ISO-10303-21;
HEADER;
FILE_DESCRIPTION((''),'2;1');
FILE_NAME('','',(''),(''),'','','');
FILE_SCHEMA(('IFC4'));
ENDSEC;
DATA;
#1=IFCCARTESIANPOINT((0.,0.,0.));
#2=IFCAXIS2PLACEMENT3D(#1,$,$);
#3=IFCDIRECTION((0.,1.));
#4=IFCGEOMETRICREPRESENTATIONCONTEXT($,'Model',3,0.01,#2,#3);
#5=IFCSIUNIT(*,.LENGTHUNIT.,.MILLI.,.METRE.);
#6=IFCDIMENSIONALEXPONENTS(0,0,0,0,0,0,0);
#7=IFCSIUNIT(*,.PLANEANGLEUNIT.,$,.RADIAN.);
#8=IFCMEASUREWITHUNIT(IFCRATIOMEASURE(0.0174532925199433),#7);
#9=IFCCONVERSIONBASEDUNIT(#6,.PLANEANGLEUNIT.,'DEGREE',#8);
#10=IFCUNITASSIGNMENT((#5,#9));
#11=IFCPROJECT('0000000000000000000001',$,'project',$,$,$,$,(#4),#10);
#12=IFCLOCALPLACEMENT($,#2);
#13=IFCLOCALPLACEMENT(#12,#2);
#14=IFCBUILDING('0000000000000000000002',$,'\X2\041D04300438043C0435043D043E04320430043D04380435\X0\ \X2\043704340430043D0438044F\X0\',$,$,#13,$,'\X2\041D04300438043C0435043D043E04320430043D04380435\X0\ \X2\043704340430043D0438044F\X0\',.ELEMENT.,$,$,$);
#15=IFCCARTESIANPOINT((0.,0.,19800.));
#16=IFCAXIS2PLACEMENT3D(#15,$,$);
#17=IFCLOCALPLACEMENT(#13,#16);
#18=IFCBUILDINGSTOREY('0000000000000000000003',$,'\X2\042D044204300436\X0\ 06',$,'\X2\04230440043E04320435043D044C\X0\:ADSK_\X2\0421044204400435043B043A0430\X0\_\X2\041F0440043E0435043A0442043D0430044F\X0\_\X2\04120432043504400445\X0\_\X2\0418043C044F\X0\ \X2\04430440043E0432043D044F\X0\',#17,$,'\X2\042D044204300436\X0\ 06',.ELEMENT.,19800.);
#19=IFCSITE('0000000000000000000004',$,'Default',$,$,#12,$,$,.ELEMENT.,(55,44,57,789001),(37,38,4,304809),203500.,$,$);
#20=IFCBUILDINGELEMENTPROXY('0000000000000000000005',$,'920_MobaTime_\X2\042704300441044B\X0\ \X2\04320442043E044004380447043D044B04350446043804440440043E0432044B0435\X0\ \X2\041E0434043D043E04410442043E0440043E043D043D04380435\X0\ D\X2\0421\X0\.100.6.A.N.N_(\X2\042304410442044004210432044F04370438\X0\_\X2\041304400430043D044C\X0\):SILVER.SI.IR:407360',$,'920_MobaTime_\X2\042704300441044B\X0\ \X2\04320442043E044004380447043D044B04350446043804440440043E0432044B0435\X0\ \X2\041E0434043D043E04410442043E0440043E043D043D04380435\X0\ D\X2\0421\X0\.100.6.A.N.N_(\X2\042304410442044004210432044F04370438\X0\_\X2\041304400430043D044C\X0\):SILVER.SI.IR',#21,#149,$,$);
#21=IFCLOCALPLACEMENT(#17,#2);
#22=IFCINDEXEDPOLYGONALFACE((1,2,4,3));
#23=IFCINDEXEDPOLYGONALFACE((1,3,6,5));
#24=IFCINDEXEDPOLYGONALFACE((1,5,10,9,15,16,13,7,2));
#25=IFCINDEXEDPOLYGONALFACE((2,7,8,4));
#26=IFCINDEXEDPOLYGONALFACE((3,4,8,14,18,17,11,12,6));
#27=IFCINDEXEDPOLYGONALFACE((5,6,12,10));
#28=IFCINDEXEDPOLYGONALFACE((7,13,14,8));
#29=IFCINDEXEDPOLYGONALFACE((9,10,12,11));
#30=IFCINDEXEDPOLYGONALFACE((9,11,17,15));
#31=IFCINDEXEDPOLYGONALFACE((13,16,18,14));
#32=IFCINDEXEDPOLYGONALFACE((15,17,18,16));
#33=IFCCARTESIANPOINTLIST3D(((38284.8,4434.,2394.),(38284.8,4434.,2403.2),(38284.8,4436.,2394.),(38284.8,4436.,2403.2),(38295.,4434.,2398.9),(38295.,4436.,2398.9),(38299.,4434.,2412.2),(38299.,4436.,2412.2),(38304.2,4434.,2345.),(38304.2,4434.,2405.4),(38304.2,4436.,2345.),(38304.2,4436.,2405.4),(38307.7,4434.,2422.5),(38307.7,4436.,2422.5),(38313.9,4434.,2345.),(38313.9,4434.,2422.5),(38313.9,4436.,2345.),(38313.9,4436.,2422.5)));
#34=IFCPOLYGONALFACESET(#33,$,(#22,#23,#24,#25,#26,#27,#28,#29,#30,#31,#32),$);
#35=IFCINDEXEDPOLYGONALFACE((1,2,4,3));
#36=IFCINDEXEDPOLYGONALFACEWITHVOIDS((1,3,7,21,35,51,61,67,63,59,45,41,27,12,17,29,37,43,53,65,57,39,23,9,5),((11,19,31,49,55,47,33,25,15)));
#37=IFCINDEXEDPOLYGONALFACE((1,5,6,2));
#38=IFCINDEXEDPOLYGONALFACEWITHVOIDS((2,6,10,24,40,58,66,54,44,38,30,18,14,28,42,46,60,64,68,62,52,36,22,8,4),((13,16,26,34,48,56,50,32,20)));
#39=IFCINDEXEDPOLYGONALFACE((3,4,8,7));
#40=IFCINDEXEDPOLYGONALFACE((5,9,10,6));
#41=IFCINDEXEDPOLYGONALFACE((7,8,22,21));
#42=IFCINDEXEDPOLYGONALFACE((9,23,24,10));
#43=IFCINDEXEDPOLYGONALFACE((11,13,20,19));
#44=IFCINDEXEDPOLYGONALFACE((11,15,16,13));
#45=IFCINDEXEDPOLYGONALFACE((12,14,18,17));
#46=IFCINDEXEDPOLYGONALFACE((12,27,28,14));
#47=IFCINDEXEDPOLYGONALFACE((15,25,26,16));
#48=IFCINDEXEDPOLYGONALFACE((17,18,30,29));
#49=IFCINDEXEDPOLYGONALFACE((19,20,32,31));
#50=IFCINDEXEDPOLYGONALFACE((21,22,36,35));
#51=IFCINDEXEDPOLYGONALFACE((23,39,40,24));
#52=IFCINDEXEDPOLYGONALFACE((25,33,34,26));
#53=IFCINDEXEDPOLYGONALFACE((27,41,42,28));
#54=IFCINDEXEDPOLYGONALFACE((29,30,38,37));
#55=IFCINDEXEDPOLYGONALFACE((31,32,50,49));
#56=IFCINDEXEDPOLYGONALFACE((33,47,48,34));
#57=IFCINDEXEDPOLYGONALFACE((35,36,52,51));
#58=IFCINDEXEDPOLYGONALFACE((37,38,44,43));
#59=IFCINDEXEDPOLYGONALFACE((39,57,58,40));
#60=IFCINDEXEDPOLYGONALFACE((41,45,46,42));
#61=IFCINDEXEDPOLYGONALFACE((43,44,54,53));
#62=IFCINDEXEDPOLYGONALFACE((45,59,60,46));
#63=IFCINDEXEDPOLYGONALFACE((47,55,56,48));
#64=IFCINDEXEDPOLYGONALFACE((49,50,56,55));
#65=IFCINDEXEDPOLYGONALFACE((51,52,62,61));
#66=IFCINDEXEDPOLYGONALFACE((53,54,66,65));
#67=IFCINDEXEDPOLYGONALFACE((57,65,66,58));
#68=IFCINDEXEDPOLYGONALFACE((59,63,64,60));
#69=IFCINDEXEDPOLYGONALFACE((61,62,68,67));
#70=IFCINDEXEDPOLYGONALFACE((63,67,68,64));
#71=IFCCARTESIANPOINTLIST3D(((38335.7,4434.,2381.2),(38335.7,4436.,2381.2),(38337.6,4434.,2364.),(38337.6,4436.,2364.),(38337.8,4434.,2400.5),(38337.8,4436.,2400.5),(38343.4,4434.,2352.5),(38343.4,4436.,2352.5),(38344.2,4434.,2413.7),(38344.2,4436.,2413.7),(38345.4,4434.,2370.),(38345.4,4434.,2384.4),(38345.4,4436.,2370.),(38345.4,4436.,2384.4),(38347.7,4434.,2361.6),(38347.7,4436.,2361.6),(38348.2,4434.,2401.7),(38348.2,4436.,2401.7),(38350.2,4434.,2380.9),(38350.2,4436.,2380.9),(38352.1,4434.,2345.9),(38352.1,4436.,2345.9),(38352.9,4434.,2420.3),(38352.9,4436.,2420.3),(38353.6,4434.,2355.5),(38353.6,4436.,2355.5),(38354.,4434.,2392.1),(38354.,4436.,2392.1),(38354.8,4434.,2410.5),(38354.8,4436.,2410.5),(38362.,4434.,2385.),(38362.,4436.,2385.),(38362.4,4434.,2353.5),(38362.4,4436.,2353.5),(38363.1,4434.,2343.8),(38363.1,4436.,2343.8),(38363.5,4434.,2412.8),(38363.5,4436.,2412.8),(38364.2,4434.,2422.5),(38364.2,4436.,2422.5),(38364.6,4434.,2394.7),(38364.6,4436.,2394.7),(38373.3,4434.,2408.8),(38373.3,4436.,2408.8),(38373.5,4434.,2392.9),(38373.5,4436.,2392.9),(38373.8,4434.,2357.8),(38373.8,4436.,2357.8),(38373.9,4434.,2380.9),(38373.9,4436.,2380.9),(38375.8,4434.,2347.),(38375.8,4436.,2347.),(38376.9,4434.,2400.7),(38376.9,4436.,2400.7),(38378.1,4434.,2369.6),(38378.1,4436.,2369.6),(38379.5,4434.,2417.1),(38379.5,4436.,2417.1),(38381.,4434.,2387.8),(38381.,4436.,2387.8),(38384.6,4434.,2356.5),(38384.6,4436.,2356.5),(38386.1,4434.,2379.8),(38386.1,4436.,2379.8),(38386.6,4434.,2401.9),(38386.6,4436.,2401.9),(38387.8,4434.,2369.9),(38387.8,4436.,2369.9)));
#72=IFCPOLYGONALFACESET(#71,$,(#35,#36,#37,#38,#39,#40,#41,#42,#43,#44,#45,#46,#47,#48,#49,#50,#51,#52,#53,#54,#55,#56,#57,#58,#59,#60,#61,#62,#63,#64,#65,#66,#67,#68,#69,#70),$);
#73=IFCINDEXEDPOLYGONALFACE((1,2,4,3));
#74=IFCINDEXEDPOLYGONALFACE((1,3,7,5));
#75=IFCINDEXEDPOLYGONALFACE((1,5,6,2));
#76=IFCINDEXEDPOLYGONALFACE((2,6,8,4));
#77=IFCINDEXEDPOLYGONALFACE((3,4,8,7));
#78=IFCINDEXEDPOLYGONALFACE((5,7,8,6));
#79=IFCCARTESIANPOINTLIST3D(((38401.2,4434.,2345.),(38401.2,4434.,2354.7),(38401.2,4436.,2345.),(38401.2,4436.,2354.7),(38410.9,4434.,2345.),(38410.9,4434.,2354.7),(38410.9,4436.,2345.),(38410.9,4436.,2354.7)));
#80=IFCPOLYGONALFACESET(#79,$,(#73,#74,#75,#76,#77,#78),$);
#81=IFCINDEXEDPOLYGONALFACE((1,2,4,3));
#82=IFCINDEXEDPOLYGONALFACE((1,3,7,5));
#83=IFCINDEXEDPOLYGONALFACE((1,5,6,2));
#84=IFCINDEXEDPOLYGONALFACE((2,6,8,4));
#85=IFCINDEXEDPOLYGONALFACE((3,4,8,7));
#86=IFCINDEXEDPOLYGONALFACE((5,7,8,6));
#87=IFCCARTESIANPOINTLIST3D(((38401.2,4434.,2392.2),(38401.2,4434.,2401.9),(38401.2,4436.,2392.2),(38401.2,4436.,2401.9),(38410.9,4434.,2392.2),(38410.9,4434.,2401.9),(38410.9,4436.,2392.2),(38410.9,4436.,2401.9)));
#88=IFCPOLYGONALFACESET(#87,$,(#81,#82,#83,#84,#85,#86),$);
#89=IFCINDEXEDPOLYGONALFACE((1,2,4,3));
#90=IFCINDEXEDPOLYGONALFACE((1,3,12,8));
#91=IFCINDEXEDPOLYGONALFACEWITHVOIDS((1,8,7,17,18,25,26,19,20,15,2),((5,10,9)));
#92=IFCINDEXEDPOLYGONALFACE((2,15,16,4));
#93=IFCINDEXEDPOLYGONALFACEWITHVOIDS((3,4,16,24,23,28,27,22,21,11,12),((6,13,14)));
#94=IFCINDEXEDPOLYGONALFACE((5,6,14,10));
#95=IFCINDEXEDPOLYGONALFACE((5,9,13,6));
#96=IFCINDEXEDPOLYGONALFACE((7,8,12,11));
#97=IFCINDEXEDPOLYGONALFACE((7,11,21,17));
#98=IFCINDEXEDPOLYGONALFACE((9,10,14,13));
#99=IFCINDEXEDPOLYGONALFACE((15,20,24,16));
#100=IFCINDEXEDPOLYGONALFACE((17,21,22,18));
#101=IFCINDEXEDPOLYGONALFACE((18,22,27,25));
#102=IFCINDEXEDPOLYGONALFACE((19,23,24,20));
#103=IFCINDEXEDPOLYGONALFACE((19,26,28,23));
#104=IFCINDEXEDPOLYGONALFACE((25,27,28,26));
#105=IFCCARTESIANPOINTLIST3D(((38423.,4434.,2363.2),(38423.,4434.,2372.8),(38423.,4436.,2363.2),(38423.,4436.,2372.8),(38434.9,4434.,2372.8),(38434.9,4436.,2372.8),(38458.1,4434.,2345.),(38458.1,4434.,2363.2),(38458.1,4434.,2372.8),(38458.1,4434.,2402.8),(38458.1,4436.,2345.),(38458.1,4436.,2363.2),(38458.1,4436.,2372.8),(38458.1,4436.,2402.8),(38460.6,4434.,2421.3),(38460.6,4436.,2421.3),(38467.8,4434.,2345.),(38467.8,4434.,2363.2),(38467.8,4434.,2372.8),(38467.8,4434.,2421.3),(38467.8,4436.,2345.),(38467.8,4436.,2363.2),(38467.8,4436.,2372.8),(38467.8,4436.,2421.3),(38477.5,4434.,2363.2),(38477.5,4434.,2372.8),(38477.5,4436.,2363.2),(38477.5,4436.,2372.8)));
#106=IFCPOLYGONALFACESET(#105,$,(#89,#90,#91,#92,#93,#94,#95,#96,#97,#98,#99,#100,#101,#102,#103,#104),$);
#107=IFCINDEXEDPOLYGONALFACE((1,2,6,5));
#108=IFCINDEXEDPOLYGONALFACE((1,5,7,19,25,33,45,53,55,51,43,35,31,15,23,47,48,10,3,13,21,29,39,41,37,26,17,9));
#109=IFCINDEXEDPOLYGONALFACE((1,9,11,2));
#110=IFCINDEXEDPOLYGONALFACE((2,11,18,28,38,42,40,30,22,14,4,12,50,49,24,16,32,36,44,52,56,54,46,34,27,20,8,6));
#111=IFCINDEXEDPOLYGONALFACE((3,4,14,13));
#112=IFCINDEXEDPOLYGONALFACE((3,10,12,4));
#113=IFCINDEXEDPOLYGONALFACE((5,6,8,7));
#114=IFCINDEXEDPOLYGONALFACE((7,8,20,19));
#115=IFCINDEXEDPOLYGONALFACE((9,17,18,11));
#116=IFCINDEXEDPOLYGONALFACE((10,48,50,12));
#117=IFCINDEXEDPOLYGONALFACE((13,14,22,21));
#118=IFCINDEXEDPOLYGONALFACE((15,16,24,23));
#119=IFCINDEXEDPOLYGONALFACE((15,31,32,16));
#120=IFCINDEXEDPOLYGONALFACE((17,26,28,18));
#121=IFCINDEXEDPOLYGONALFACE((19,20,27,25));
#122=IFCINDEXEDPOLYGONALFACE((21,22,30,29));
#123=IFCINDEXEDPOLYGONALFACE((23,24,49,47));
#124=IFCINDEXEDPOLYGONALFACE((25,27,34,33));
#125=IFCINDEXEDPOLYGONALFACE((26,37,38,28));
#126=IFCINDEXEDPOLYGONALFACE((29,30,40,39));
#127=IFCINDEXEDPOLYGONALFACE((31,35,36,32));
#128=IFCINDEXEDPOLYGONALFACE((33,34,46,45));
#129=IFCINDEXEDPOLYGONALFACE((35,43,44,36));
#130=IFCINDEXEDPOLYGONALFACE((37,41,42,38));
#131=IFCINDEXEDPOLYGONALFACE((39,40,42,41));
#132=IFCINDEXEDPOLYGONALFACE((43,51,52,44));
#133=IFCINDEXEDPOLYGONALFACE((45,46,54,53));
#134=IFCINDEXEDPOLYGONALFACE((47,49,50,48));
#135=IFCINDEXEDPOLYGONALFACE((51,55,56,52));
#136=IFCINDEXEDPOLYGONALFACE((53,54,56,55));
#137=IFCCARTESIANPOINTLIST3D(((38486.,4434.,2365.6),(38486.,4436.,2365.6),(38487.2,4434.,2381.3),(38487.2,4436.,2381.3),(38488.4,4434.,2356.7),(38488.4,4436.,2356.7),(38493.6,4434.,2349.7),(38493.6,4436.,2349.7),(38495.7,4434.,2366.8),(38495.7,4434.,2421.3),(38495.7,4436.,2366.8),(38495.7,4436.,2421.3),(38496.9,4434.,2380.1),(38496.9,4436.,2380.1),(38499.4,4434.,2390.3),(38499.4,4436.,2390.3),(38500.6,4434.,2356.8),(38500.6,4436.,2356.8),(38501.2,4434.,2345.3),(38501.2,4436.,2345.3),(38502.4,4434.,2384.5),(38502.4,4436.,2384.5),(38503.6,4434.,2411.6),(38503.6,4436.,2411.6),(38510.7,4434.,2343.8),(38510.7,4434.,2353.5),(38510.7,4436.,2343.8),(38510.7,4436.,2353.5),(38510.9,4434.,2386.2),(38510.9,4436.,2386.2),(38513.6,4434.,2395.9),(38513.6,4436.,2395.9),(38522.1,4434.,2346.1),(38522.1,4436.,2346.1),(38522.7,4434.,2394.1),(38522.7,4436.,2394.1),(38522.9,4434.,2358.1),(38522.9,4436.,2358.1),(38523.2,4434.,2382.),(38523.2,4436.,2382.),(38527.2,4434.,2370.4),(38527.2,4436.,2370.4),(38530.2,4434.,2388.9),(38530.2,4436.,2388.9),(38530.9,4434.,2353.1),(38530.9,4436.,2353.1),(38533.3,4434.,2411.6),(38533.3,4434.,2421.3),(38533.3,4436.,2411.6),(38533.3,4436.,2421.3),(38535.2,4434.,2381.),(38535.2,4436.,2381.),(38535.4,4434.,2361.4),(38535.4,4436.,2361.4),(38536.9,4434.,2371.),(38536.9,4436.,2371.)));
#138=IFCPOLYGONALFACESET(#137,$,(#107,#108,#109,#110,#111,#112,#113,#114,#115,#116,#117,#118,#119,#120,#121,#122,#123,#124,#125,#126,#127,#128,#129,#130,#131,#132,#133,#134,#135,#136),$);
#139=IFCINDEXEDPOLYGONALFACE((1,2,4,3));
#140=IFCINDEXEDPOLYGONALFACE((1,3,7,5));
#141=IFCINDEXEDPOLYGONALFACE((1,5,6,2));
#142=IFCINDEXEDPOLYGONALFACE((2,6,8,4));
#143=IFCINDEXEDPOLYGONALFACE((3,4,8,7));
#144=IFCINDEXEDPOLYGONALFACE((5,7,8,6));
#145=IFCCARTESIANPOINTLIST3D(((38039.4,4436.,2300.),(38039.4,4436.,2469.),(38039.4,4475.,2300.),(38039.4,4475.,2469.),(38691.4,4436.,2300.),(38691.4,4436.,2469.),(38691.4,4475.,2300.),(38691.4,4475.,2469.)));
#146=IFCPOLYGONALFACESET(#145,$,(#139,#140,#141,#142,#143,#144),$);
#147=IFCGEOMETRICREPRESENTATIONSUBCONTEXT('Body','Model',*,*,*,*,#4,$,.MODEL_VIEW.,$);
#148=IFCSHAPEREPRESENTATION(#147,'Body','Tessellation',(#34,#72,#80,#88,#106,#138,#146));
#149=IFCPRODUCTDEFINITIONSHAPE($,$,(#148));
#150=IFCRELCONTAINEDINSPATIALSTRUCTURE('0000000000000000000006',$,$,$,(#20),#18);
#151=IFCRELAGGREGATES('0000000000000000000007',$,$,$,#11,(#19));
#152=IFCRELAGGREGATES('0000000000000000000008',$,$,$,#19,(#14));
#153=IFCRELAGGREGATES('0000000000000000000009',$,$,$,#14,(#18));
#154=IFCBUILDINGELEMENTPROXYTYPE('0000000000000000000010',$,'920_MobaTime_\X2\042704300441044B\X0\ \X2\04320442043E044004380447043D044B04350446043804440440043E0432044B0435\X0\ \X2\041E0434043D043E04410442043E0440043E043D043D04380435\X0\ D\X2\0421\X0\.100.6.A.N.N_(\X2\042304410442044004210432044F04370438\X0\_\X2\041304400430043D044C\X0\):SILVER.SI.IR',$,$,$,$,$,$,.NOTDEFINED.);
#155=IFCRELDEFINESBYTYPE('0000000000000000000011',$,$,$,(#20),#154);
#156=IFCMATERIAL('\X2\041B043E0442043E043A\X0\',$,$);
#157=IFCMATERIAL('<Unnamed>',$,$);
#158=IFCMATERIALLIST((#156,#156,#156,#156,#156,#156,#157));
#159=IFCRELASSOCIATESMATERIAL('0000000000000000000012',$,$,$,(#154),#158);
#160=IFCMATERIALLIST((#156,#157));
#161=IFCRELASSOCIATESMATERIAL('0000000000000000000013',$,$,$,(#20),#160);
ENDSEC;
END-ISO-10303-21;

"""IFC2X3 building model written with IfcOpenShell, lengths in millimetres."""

from ifc_helpers import new_model, entity, si_unit, converted_unit, direction, frame, origin, origin_2d_with_axis, place, context, subcontext, project, spatial, polyline, rectangle, outline, extrude, source, transform, mapped, material, material_list, type_object, type_shapes, element, save


model = new_model("IFC2X3")

# Units and contexts
model_context = context("Model", 3, precision=0.01, world=origin(), true_north=direction((0.0, 1.0)))
body_context = subcontext(model_context, "Body", "Model", "MODEL_VIEW")
ifc_project = project(units=[si_unit("LENGTHUNIT", "METRE", prefix="MILLI"), converted_unit("PLANEANGLEUNIT", "DEGREE", entity("IfcRatioMeasure", 0.0174532925199433), si_unit("PLANEANGLEUNIT", "RADIAN"), dimensions=[0, 0, 0, 0, 0, 0, 0])], contexts=[model_context])

# Site, building, storey
site_placement = place(None, frame((0.0, 0.0, 0.0)))
site = spatial("IfcSite", under=ifc_project, at=site_placement, Name="Default", CompositionType="ELEMENT", RefLatitude=(55, 44, 57, 789001), RefLongitude=(37, 38, 4, 304809), RefElevation=203500.0)
building_placement = place(site_placement, origin())
building = spatial("IfcBuilding", under=site, at=building_placement, Name="Наименование здания", LongName="Наименование здания", CompositionType="ELEMENT")
storey_placement = place(building_placement, frame((0.0, 0.0, 19800.0)))
storey = spatial("IfcBuildingStorey", under=building, at=storey_placement, Name="Этаж 06", ObjectType="Уровень:ADSK_Стрелка_Проектная_Вверх_Имя уровня", LongName="Этаж 06", CompositionType="ELEMENT", Elevation=19800.0)

# Building element proxy
ifc_material_1 = material(Name="Лоток")
ifc_material_2 = material(Name="<Unnamed>")
ifc_material_list_1 = material_list([ifc_material_1, ifc_material_1, ifc_material_1, ifc_material_1, ifc_material_1, ifc_material_1, ifc_material_2])
building_element_proxy_type_1 = type_object("IfcBuildingElementProxyType", Name="920_MobaTime_Часы вторичныецифровые Односторонние DС.100.6.A.N.N_(УстрСвязи_Грань):SILVER.SI.IR", PredefinedType="NOTDEFINED", material=ifc_material_list_1)
shared_shape_1 = source(origin(), body_context, "Body", "SweptSolid", [
    extrude(outline(polyline([(-49.3, -13.1), (28.2, -13.1), (28.2, -6.8), (17.9, 1.8), (8.9, 16.0), (-0.3, 16.0), (4.6, 5.8), (11.1, -3.4), (-49.3, -3.4), (-49.3, -13.1)])), frame((-64.6, 9.8, 39.0), z_axis=(0.0, 0.0, 1.0), x_axis=(0.0, 1.0, 0.0)), (0.0, 0.0, 1.0), 2.0),
    extrude(outline(polyline([(2.2, -27.6), (19.0, -27.6), (30.5, -16.1), (33.3, -4.9), (31.0, 5.8), (21.8, 17.2), (5.2, 27.3), (-11.1, 33.0), (-24.0, 32.7), (-33.6, 27.6), (-40.3, 18.6), (-42.8, 5.7), (-38.0, -6.3), (-27.2, -15.0), (-17.5, -17.7), (-8.2, -16.4), (-0.3, -11.9), (5.1, -4.5), (7.3, 6.2), (4.0, 17.2), (18.5, 7.3), (23.6, -2.4), (22.0, -11.4), (14.2, -18.4), (5.3, -18.3), (2.2, -27.6)]), holes=[polyline([(-9.0, 23.3), (-1.3, 14.4), (-2.6, 2.0), (-11.4, -7.0), (-23.4, -6.1), (-32.2, 2.9), (-31.2, 15.1), (-25.6, 22.1), (-17.5, 24.9), (-9.0, 23.3)])]), frame((-2.7, 3.6, 39.0), z_axis=(0.0, 0.0, 1.0), x_axis=(-0.427649, 0.903945, 0.0)), (0.0, 0.0, 1.0), 2.0),
    extrude(rectangle(XDim=9.7, YDim=9.7, at=origin_2d_with_axis()), frame((40.6, -34.7, 39.0)), (0.0, 0.0, 1.0), 2.0),
    extrude(rectangle(XDim=9.7, YDim=9.7, at=origin_2d_with_axis()), frame((40.6, 12.6, 39.0)), (0.0, 0.0, 1.0), 2.0),
    extrude(outline(polyline([(-0.9, -28.1), (8.8, -28.1), (8.8, -9.9), (18.5, -9.9), (18.5, -0.2), (8.8, -0.2), (8.8, 48.3), (1.5, 48.3), (-36.0, -0.2), (-36.0, -9.9), (-0.9, -9.9), (-0.9, -28.1)]), holes=[polyline([(-0.9, -0.2), (-24.1, -0.2), (-0.9, 29.7), (-0.9, -0.2)])]), frame((93.6, -11.4, 39.0)), (0.0, 0.0, 1.0), 2.0),
    extrude(outline(polyline([(3.3, -28.3), (12.5, -28.3), (20.5, -25.0), (26.8, -18.8), (30.7, -10.0), (31.4, 1.6), (26.9, 11.8), (20.1, 18.4), (11.1, 22.3), (1.0, 23.3), (-7.9, 20.4), (-14.9, 14.5), (-18.9, 6.2), (-17.1, -9.0), (-36.7, 0.5), (-29.1, 29.3), (-38.5, 31.7), (-48.1, -4.6), (-11.6, -23.0), (-8.0, -14.0), (-10.8, -7.6), (-10.2, 1.1), (-3.0, 11.8), (9.2, 12.8), (20.0, 5.4), (21.3, -7.5), (15.5, -16.4), (4.6, -18.6), (3.3, -28.3)])), frame((147.1, -8.5, 39.0), z_axis=(0.0, 0.0, 1.0), x_axis=(0.256974, -0.966418, 0.0)), (0.0, 0.0, 1.0), 2.0),
    extrude(rectangle(XDim=652.0, YDim=169.0, at=origin_2d_with_axis()), frame((0.0, 0.0, 0.0), z_axis=(0.0, 0.0, 1.0), x_axis=(-1.0, 0.0, 0.0)), (0.0, 0.0, 1.0), 39.0),
])
type_shapes(building_element_proxy_type_1, [shared_shape_1])
ifc_material_list_2 = material_list([ifc_material_1, ifc_material_2])
proxy_1_placement = place(storey_placement, frame((38365.4, 4475.0, 2384.5), z_axis=(0.0, -1.0, 0.0), x_axis=(1.0, 0.0, 0.0)))
element("IfcBuildingElementProxy", 1, at=proxy_1_placement, inside=storey, type_object=building_element_proxy_type_1, material=ifc_material_list_2, Name="920_MobaTime_Часы вторичныецифровые Односторонние DС.100.6.A.N.N_(УстрСвязи_Грань):SILVER.SI.IR:407360", ObjectType="920_MobaTime_Часы вторичныецифровые Односторонние DС.100.6.A.N.N_(УстрСвязи_Грань):SILVER.SI.IR", context=body_context, shape_type="MappedRepresentation", body=[
    mapped(shared_shape_1, transform((0.0, 0.0, 0.0), scale=1.0)),
])

save(model, "model.ifc")
